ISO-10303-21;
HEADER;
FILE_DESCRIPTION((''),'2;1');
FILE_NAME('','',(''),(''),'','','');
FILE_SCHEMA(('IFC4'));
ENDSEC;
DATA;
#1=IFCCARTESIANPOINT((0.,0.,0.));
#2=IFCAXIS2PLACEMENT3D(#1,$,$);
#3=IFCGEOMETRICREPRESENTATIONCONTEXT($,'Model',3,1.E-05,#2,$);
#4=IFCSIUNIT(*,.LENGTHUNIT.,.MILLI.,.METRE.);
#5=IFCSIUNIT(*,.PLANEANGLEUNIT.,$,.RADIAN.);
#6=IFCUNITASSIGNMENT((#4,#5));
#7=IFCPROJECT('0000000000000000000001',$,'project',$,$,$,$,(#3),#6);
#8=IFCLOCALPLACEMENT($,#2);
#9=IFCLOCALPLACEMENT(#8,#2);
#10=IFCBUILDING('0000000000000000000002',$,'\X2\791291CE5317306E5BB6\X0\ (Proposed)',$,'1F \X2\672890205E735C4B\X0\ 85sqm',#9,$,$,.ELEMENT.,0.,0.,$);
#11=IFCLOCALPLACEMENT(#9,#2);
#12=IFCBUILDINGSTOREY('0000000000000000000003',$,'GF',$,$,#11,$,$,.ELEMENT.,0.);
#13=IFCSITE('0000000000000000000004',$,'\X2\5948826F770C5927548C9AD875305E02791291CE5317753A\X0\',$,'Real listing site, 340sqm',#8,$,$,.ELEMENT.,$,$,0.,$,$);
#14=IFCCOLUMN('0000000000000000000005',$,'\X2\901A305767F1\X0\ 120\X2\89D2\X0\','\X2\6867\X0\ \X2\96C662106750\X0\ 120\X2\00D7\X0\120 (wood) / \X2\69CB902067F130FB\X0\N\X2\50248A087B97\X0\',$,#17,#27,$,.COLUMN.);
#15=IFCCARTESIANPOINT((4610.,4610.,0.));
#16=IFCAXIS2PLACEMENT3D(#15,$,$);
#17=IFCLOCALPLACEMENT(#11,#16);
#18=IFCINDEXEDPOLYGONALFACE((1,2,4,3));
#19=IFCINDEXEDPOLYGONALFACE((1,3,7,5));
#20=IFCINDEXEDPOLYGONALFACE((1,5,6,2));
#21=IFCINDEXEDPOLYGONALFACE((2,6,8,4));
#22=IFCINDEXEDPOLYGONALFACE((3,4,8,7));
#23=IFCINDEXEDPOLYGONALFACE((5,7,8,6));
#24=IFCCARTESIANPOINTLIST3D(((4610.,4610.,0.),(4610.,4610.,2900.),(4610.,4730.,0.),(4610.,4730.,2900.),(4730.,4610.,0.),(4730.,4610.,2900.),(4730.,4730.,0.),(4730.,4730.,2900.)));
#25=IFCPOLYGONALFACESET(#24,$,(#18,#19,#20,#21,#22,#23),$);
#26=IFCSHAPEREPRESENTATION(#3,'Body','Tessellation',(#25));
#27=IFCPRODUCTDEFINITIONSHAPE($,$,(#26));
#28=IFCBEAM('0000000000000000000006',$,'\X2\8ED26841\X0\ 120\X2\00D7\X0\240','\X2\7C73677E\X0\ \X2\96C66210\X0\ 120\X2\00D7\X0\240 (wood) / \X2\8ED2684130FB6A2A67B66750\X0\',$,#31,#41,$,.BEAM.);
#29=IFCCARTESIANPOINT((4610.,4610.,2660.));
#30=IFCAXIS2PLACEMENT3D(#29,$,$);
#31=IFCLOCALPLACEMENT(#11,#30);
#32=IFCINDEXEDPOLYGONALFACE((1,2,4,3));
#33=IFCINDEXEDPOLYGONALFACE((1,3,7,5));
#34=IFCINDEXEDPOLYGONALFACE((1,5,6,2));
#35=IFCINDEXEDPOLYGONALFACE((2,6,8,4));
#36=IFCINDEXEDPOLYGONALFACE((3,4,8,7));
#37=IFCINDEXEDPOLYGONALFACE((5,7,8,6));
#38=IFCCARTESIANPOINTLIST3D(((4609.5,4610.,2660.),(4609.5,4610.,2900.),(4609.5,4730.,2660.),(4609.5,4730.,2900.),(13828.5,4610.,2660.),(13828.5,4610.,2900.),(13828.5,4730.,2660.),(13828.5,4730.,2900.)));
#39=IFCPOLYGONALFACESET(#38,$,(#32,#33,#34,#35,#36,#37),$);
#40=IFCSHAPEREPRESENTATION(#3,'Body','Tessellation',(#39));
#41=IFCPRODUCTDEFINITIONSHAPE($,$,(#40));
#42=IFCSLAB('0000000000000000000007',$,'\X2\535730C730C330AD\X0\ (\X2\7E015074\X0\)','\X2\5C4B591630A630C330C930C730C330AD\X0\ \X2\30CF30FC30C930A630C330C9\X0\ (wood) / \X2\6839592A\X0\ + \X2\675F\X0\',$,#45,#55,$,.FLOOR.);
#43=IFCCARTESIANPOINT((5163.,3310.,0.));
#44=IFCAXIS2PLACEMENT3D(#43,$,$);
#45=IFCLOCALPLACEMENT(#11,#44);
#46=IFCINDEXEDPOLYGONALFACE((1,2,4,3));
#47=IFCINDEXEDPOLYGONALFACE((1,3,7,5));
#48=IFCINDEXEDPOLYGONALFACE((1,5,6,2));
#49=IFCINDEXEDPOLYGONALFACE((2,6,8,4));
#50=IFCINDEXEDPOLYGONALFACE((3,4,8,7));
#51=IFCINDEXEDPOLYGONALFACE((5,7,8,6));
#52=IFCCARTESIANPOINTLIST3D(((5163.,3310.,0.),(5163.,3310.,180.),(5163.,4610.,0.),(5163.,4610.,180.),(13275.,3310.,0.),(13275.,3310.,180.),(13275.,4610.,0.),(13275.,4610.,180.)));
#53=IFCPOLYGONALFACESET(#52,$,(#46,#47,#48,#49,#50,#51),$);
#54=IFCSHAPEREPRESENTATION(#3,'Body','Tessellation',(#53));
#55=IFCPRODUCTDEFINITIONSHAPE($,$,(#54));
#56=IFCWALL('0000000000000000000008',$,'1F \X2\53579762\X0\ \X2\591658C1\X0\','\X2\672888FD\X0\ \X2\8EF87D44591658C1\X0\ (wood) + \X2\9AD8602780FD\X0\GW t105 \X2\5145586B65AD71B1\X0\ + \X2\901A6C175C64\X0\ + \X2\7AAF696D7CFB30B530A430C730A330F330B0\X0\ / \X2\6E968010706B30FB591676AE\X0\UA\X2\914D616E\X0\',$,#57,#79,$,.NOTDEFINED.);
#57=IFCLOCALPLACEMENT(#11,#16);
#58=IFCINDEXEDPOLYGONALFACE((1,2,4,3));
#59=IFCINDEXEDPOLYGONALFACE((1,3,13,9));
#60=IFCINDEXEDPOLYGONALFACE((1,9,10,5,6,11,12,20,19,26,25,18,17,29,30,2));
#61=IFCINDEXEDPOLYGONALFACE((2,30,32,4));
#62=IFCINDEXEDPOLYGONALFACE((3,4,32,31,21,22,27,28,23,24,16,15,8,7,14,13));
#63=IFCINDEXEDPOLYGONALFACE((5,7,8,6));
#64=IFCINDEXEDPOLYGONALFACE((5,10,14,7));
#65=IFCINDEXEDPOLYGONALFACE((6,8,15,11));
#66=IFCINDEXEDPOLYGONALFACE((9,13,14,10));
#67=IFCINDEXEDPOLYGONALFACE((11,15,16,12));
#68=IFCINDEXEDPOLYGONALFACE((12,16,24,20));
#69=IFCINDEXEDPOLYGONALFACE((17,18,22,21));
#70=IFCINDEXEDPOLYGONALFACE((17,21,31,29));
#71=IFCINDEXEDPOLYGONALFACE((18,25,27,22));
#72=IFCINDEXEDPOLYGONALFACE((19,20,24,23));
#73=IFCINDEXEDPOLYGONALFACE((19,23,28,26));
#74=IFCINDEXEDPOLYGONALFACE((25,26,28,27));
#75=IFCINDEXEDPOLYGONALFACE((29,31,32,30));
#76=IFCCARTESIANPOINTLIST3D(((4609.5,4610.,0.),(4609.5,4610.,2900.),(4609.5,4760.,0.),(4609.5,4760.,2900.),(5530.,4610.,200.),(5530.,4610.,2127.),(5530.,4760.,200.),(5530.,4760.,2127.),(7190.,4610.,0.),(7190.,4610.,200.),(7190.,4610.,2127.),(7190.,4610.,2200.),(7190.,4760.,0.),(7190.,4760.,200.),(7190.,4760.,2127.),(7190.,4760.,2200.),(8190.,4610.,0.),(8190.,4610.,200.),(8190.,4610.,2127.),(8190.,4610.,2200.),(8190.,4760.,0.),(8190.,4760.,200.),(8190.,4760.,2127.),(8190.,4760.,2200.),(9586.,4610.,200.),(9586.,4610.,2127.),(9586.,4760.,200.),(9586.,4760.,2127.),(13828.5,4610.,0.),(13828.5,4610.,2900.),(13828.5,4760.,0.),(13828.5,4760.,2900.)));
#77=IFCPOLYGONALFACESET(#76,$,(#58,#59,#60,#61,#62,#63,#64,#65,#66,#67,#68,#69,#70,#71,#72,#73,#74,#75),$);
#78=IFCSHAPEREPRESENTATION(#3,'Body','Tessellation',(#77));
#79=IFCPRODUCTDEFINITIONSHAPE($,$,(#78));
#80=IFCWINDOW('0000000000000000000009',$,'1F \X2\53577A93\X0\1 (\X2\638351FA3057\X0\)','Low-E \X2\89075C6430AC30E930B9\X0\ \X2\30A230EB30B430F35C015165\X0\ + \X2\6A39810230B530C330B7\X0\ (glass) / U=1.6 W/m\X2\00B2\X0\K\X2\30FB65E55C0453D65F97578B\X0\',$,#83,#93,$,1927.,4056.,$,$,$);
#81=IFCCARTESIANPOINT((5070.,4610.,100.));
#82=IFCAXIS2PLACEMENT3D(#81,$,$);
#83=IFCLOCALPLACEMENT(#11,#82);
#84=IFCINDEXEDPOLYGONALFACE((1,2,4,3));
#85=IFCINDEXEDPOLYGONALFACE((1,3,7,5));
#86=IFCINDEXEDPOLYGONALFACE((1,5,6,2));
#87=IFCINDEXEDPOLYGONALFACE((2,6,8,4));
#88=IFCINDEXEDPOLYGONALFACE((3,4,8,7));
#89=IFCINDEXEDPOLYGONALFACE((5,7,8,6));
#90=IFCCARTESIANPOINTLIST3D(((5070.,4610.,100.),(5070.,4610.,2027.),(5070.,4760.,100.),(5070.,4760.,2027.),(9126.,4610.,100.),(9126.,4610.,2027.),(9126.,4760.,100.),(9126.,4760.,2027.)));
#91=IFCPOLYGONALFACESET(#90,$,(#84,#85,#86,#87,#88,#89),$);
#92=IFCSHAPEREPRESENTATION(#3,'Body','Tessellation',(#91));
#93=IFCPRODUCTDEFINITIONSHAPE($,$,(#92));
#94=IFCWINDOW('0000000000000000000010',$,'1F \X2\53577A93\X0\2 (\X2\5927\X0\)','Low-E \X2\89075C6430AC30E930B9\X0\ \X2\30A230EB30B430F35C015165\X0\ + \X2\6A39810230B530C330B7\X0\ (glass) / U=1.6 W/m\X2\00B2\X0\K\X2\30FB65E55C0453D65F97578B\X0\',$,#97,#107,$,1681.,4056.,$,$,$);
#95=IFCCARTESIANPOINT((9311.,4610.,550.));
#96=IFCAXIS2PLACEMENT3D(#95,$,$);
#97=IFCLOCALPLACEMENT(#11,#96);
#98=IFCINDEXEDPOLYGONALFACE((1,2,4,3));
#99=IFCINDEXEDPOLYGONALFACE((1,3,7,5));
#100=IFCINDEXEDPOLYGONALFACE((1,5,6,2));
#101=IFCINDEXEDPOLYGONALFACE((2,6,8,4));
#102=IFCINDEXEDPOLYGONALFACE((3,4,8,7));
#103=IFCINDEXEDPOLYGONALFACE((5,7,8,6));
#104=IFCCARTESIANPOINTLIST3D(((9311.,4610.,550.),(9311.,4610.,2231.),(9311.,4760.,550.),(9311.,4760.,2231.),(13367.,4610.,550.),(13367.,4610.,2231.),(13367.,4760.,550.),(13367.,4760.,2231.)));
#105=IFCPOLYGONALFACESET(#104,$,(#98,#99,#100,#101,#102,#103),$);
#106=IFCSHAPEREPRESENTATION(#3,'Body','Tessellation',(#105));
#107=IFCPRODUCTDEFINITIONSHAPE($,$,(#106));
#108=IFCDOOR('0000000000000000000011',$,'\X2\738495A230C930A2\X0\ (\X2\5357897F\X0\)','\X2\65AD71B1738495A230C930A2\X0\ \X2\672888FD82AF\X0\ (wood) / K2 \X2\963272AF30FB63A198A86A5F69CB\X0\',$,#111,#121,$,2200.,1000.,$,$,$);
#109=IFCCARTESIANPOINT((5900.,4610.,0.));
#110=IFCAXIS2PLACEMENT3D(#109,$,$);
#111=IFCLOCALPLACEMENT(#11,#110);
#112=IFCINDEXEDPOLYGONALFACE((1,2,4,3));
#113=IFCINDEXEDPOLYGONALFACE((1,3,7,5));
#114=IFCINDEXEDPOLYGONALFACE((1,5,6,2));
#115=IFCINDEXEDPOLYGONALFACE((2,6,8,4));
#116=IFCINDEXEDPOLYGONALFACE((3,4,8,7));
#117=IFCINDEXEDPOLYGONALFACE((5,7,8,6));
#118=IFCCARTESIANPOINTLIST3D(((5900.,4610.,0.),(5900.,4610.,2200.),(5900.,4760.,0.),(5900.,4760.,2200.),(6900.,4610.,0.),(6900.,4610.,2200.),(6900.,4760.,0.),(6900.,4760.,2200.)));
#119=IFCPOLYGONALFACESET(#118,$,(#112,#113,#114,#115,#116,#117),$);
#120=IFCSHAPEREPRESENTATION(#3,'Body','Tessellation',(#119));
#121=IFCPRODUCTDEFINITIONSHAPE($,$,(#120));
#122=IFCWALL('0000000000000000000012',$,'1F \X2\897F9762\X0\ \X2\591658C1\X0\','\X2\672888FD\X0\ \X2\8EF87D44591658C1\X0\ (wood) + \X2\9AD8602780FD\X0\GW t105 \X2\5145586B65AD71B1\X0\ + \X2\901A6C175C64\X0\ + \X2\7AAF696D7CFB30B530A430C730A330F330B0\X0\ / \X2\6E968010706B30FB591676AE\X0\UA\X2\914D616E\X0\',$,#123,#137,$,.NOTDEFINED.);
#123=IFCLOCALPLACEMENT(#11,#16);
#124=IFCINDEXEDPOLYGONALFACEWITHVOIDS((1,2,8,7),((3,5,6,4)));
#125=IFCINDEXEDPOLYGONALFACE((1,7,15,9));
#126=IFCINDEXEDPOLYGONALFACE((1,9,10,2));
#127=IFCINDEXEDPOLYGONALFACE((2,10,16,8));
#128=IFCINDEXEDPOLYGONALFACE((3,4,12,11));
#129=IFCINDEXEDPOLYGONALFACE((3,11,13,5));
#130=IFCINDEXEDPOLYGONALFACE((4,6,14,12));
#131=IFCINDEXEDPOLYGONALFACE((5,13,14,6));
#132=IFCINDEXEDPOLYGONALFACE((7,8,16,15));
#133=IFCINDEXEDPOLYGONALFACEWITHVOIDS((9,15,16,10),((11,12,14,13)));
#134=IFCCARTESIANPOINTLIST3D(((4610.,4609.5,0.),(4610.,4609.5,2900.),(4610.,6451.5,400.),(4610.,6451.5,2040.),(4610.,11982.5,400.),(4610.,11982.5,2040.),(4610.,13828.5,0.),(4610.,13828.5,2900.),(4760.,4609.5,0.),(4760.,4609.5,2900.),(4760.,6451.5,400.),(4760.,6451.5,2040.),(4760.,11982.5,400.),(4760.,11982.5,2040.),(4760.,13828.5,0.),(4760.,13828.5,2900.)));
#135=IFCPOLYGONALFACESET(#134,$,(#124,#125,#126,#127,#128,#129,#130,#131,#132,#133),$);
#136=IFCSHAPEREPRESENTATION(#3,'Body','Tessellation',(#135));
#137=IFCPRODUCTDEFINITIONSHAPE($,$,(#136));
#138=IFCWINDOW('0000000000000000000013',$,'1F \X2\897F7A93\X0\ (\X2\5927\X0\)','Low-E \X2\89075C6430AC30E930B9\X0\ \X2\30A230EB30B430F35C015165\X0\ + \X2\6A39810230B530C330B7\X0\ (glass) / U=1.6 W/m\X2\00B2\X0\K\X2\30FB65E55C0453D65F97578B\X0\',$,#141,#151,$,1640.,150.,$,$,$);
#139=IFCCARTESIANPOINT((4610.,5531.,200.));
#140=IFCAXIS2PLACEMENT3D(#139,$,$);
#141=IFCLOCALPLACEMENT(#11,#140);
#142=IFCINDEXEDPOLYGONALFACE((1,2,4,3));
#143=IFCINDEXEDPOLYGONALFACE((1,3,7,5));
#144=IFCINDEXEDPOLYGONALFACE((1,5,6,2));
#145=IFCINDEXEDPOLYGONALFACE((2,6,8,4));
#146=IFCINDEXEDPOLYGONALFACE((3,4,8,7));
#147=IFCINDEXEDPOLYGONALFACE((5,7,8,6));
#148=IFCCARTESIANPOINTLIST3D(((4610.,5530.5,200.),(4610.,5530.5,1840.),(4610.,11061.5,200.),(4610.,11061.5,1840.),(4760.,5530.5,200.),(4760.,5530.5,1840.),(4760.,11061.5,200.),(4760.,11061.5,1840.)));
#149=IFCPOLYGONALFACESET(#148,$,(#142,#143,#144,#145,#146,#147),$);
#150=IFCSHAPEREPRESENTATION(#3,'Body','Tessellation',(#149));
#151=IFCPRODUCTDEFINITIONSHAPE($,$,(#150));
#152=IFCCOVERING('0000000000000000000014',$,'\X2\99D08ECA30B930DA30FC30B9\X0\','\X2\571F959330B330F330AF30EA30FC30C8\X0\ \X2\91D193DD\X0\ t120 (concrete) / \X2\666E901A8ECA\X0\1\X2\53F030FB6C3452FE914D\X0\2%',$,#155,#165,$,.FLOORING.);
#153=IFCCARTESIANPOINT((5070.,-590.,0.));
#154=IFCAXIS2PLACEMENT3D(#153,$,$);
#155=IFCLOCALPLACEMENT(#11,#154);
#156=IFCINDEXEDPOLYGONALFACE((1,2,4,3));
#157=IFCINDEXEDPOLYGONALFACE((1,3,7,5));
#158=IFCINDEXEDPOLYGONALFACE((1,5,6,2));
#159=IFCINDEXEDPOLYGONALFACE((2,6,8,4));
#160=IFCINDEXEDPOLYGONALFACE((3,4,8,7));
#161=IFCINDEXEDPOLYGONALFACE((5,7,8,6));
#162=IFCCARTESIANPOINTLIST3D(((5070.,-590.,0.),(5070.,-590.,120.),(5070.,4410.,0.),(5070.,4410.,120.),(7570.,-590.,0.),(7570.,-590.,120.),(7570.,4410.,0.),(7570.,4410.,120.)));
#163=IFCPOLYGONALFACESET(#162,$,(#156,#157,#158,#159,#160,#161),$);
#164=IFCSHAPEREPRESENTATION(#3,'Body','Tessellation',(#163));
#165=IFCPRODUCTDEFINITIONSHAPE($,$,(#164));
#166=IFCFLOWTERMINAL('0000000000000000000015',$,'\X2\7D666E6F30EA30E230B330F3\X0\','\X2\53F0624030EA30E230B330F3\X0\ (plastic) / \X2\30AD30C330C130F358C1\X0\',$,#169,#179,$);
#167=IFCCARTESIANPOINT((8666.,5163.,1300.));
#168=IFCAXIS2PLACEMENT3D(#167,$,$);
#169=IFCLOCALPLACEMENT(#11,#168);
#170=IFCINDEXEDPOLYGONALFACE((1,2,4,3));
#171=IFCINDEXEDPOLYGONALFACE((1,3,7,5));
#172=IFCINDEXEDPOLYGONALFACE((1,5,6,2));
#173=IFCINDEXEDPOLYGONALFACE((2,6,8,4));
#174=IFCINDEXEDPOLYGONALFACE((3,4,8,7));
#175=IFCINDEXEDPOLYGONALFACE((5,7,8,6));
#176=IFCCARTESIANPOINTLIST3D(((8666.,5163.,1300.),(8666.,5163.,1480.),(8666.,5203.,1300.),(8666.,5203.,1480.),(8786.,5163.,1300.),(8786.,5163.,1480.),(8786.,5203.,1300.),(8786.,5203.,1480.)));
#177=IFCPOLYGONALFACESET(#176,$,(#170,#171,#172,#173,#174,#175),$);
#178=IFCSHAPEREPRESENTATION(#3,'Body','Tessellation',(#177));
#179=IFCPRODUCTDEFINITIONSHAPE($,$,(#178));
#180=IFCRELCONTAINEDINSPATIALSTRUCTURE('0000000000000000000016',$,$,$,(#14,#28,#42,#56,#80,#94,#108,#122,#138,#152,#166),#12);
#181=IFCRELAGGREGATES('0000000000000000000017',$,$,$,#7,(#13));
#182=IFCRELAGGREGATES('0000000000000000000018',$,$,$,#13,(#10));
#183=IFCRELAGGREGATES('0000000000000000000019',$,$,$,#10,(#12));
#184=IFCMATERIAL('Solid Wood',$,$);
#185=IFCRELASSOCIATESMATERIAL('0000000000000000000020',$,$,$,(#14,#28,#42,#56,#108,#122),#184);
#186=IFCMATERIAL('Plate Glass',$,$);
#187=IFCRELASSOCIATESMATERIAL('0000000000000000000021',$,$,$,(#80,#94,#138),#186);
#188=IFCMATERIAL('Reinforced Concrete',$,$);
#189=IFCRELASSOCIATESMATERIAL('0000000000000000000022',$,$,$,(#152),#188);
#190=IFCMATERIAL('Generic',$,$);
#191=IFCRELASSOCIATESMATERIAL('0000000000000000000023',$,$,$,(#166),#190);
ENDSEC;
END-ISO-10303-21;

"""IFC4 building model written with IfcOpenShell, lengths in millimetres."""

from ifc_helpers import new_model, si_unit, frame, frame_2d, origin, place, context, project, spatial, rectangle, extrude, material, element, fill, save


model = new_model("IFC4")

# Units and contexts
model_context = context("Model", 3, precision=1e-05, world=origin())
ifc_project = project(units=[si_unit("LENGTHUNIT", "METRE", prefix="MILLI"), si_unit("PLANEANGLEUNIT", "RADIAN")], contexts=[model_context])

# Site, building, storey
site_placement = place(None, origin())
site = spatial("IfcSite", under=ifc_project, at=site_placement, Name="奈良県大和高田市礒野北町", ObjectType="Real listing site, 340sqm", CompositionType="ELEMENT", RefElevation=0.0)
building_placement = place(site_placement, origin())
building = spatial("IfcBuilding", under=site, at=building_placement, Name="礒野北の家 (Proposed)", ObjectType="1F 木造平屋 85sqm", CompositionType="ELEMENT", ElevationOfRefHeight=0.0, ElevationOfTerrain=0.0)
storey_placement = place(building_placement, origin())
storey = spatial("IfcBuildingStorey", under=building, at=storey_placement, Name="GF", CompositionType="ELEMENT", Elevation=0.0)

# Column
ifc_material_1 = material(Name="Solid Wood")
column_1_placement = place(storey_placement, frame((4610.0, 4610.0, 0.0)))
element("IfcColumn", 1, at=column_1_placement, inside=storey, material=ifc_material_1, Name="通し柱 120角", Description="桧 集成材 120×120 (wood) / 構造柱・N値計算", PredefinedType="COLUMN", context=model_context, shape_type="SweptSolid", body=[
    extrude(rectangle(XDim=120.0, YDim=120.0, at=frame_2d((60.0, 60.0))), frame((4610.0, 4610.0, 0.0)), (0.0, 0.0, 1.0), 2900.0),
])

# Beam
beam_1_placement = place(storey_placement, frame((4610.0, 4610.0, 2660.0)))
element("IfcBeam", 2, at=beam_1_placement, inside=storey, material=ifc_material_1, Name="軒桁 120×240", Description="米松 集成 120×240 (wood) / 軒桁・横架材", PredefinedType="BEAM", context=model_context, shape_type="SweptSolid", body=[
    extrude(rectangle(XDim=9219.0, YDim=120.0, at=frame_2d((4609.0, 60.0))), frame((4610.0, 4610.0, 2660.0)), (0.0, 0.0, 1.0), 240.0),
])

# Slab
ifc_material_2 = material(Name="Reinforced Concrete")
slab_1_placement = place(storey_placement, frame((5163.0, 3310.0, 0.0)))
element("IfcSlab", 3, at=slab_1_placement, inside=storey, material=ifc_material_1, Name="南デッキ (縁側)", Description="屋外ウッドデッキ ハードウッド (wood) / 根太 + 束", PredefinedType="FLOOR", context=model_context, shape_type="SweptSolid", body=[
    extrude(rectangle(XDim=8112.0, YDim=1300.0, at=frame_2d((4056.0, 650.0))), frame((5163.0, 3310.0, 0.0)), (0.0, 0.0, 1.0), 180.0),
])

# Wall, openings, windows, door
wall_1_placement = place(storey_placement, frame((4610.0, 4610.0, 0.0)))
wall_1 = element("IfcWall", 4, at=wall_1_placement, inside=storey, material=ifc_material_1, Name="1F 南面 外壁", Description="木製 軸組外壁 (wood) + 高性能GW t105 充填断熱 + 通気層 + 窯業系サイディング / 準耐火・外皮UA配慮", PredefinedType="NOTDEFINED", context=model_context, shape_type="SweptSolid", body=[
    extrude(rectangle(XDim=9219.0, YDim=150.0, at=frame_2d((4609.0, 75.0))), frame((4610.0, 4610.0, 0.0)), (0.0, 0.0, 1.0), 2900.0),
])
opening_1_placement = place(storey_placement, frame((5070.0, 4610.0, 100.0)))
opening_1 = element("IfcOpeningElement", 5, at=opening_1_placement, cuts=wall_1, PredefinedType="NOTDEFINED", context=model_context, shape_type="SweptSolid", body=[
    extrude(rectangle(XDim=4056.0, YDim=150.0, at=frame_2d((2028.0, 75.0))), frame((5070.0, 4610.0, 100.0)), (0.0, 0.0, 1.0), 1927.0),
])
opening_2_placement = place(storey_placement, frame((9311.0, 4610.0, 550.0)))
opening_2 = element("IfcOpeningElement", 6, at=opening_2_placement, cuts=wall_1, PredefinedType="NOTDEFINED", context=model_context, shape_type="SweptSolid", body=[
    extrude(rectangle(XDim=4056.0, YDim=150.0, at=frame_2d((2028.0, 75.0))), frame((9311.0, 4610.0, 550.0)), (0.0, 0.0, 1.0), 1681.0),
])
opening_3_placement = place(storey_placement, frame((5900.0, 4610.0, 0.0)))
opening_3 = element("IfcOpeningElement", 7, at=opening_3_placement, cuts=wall_1, PredefinedType="NOTDEFINED", context=model_context, shape_type="SweptSolid", body=[
    extrude(rectangle(XDim=1000.0, YDim=150.0, at=frame_2d((500.0, 75.0))), frame((5900.0, 4610.0, 0.0)), (0.0, 0.0, 1.0), 2200.0),
])
ifc_material_3 = material(Name="Plate Glass")
window_1_placement = place(storey_placement, frame((5070.0, 4610.0, 100.0)))
window_1 = element("IfcWindow", 8, at=window_1_placement, inside=storey, material=ifc_material_3, Name="1F 南窓1 (掃出し)", Description="Low-E 複層ガラス アルゴン封入 + 樹脂サッシ (glass) / U=1.6 W/m²K・日射取得型", OverallHeight=1927.0, OverallWidth=4056.0, context=model_context, shape_type="SweptSolid", body=[
    extrude(rectangle(XDim=4056.0, YDim=150.0, at=frame_2d((2028.0, 75.0))), frame((5070.0, 4610.0, 100.0)), (0.0, 0.0, 1.0), 1927.0),
])
fill(opening_1, window_1)
window_2_placement = place(storey_placement, frame((9311.0, 4610.0, 550.0)))
window_2 = element("IfcWindow", 9, at=window_2_placement, inside=storey, material=ifc_material_3, Name="1F 南窓2 (大)", Description="Low-E 複層ガラス アルゴン封入 + 樹脂サッシ (glass) / U=1.6 W/m²K・日射取得型", OverallHeight=1681.0, OverallWidth=4056.0, context=model_context, shape_type="SweptSolid", body=[
    extrude(rectangle(XDim=4056.0, YDim=150.0, at=frame_2d((2028.0, 75.0))), frame((9311.0, 4610.0, 550.0)), (0.0, 0.0, 1.0), 1681.0),
])
fill(opening_2, window_2)
door_placement = place(storey_placement, frame((5900.0, 4610.0, 0.0)))
door = element("IfcDoor", 10, at=door_placement, inside=storey, material=ifc_material_1, Name="玄関ドア (南西)", Description="断熱玄関ドア 木製芯 (wood) / K2 防犯・採風機構", OverallHeight=2200.0, OverallWidth=1000.0, context=model_context, shape_type="SweptSolid", body=[
    extrude(rectangle(XDim=1000.0, YDim=150.0, at=frame_2d((500.0, 75.0))), frame((5900.0, 4610.0, 0.0)), (0.0, 0.0, 1.0), 2200.0),
])
fill(opening_3, door)

# Wall, opening, window
wall_2_placement = place(storey_placement, frame((4610.0, 4610.0, 0.0)))
wall_2 = element("IfcWall", 11, at=wall_2_placement, inside=storey, material=ifc_material_1, Name="1F 西面 外壁", Description="木製 軸組外壁 (wood) + 高性能GW t105 充填断熱 + 通気層 + 窯業系サイディング / 準耐火・外皮UA配慮", PredefinedType="NOTDEFINED", context=model_context, shape_type="SweptSolid", body=[
    extrude(rectangle(XDim=150.0, YDim=9219.0, at=frame_2d((75.0, 4609.0))), frame((4610.0, 4610.0, 0.0)), (0.0, 0.0, 1.0), 2900.0),
])
opening_4_placement = place(storey_placement, frame((4610.0, 5531.0, 200.0)))
opening_4 = element("IfcOpeningElement", 12, at=opening_4_placement, cuts=wall_2, PredefinedType="NOTDEFINED", context=model_context, shape_type="SweptSolid", body=[
    extrude(rectangle(XDim=150.0, YDim=5531.0, at=frame_2d((75.0, 2765.0))), frame((4610.0, 5531.0, 200.0)), (0.0, 0.0, 1.0), 1640.0),
])
window_3_placement = place(storey_placement, frame((4610.0, 5531.0, 200.0)))
window_3 = element("IfcWindow", 13, at=window_3_placement, inside=storey, material=ifc_material_3, Name="1F 西窓 (大)", Description="Low-E 複層ガラス アルゴン封入 + 樹脂サッシ (glass) / U=1.6 W/m²K・日射取得型", OverallHeight=1640.0, OverallWidth=150.0, context=model_context, shape_type="SweptSolid", body=[
    extrude(rectangle(XDim=150.0, YDim=5531.0, at=frame_2d((75.0, 2765.0))), frame((4610.0, 5531.0, 200.0)), (0.0, 0.0, 1.0), 1640.0),
])
fill(opening_4, window_3)

# Covering
ifc_material_4 = material(Name="Generic")
covering_1_placement = place(storey_placement, frame((5070.0, -590.0, 0.0)))
element("IfcCovering", 14, at=covering_1_placement, inside=storey, material=ifc_material_2, Name="駐車スペース", Description="土間コンクリート 金鏝 t120 (concrete) / 普通車1台・水勾配2%", PredefinedType="FLOORING", context=model_context, shape_type="SweptSolid", body=[
    extrude(rectangle(XDim=2500.0, YDim=5000.0, at=frame_2d((1250.0, 2500.0))), frame((5070.0, -590.0, 0.0)), (0.0, 0.0, 1.0), 120.0),
])

# Flow terminal
flow_terminal_placement = place(storey_placement, frame((8666.0, 5163.0, 1300.0)))
element("IfcFlowTerminal", 15, at=flow_terminal_placement, inside=storey, material=ifc_material_4, Name="給湯リモコン", Description="台所リモコン (plastic) / キッチン壁", context=model_context, shape_type="SweptSolid", body=[
    extrude(rectangle(XDim=120.0, YDim=40.0, at=frame_2d((60.0, 20.0))), frame((8666.0, 5163.0, 1300.0)), (0.0, 0.0, 1.0), 180.0),
])

save(model, "model.ifc")
